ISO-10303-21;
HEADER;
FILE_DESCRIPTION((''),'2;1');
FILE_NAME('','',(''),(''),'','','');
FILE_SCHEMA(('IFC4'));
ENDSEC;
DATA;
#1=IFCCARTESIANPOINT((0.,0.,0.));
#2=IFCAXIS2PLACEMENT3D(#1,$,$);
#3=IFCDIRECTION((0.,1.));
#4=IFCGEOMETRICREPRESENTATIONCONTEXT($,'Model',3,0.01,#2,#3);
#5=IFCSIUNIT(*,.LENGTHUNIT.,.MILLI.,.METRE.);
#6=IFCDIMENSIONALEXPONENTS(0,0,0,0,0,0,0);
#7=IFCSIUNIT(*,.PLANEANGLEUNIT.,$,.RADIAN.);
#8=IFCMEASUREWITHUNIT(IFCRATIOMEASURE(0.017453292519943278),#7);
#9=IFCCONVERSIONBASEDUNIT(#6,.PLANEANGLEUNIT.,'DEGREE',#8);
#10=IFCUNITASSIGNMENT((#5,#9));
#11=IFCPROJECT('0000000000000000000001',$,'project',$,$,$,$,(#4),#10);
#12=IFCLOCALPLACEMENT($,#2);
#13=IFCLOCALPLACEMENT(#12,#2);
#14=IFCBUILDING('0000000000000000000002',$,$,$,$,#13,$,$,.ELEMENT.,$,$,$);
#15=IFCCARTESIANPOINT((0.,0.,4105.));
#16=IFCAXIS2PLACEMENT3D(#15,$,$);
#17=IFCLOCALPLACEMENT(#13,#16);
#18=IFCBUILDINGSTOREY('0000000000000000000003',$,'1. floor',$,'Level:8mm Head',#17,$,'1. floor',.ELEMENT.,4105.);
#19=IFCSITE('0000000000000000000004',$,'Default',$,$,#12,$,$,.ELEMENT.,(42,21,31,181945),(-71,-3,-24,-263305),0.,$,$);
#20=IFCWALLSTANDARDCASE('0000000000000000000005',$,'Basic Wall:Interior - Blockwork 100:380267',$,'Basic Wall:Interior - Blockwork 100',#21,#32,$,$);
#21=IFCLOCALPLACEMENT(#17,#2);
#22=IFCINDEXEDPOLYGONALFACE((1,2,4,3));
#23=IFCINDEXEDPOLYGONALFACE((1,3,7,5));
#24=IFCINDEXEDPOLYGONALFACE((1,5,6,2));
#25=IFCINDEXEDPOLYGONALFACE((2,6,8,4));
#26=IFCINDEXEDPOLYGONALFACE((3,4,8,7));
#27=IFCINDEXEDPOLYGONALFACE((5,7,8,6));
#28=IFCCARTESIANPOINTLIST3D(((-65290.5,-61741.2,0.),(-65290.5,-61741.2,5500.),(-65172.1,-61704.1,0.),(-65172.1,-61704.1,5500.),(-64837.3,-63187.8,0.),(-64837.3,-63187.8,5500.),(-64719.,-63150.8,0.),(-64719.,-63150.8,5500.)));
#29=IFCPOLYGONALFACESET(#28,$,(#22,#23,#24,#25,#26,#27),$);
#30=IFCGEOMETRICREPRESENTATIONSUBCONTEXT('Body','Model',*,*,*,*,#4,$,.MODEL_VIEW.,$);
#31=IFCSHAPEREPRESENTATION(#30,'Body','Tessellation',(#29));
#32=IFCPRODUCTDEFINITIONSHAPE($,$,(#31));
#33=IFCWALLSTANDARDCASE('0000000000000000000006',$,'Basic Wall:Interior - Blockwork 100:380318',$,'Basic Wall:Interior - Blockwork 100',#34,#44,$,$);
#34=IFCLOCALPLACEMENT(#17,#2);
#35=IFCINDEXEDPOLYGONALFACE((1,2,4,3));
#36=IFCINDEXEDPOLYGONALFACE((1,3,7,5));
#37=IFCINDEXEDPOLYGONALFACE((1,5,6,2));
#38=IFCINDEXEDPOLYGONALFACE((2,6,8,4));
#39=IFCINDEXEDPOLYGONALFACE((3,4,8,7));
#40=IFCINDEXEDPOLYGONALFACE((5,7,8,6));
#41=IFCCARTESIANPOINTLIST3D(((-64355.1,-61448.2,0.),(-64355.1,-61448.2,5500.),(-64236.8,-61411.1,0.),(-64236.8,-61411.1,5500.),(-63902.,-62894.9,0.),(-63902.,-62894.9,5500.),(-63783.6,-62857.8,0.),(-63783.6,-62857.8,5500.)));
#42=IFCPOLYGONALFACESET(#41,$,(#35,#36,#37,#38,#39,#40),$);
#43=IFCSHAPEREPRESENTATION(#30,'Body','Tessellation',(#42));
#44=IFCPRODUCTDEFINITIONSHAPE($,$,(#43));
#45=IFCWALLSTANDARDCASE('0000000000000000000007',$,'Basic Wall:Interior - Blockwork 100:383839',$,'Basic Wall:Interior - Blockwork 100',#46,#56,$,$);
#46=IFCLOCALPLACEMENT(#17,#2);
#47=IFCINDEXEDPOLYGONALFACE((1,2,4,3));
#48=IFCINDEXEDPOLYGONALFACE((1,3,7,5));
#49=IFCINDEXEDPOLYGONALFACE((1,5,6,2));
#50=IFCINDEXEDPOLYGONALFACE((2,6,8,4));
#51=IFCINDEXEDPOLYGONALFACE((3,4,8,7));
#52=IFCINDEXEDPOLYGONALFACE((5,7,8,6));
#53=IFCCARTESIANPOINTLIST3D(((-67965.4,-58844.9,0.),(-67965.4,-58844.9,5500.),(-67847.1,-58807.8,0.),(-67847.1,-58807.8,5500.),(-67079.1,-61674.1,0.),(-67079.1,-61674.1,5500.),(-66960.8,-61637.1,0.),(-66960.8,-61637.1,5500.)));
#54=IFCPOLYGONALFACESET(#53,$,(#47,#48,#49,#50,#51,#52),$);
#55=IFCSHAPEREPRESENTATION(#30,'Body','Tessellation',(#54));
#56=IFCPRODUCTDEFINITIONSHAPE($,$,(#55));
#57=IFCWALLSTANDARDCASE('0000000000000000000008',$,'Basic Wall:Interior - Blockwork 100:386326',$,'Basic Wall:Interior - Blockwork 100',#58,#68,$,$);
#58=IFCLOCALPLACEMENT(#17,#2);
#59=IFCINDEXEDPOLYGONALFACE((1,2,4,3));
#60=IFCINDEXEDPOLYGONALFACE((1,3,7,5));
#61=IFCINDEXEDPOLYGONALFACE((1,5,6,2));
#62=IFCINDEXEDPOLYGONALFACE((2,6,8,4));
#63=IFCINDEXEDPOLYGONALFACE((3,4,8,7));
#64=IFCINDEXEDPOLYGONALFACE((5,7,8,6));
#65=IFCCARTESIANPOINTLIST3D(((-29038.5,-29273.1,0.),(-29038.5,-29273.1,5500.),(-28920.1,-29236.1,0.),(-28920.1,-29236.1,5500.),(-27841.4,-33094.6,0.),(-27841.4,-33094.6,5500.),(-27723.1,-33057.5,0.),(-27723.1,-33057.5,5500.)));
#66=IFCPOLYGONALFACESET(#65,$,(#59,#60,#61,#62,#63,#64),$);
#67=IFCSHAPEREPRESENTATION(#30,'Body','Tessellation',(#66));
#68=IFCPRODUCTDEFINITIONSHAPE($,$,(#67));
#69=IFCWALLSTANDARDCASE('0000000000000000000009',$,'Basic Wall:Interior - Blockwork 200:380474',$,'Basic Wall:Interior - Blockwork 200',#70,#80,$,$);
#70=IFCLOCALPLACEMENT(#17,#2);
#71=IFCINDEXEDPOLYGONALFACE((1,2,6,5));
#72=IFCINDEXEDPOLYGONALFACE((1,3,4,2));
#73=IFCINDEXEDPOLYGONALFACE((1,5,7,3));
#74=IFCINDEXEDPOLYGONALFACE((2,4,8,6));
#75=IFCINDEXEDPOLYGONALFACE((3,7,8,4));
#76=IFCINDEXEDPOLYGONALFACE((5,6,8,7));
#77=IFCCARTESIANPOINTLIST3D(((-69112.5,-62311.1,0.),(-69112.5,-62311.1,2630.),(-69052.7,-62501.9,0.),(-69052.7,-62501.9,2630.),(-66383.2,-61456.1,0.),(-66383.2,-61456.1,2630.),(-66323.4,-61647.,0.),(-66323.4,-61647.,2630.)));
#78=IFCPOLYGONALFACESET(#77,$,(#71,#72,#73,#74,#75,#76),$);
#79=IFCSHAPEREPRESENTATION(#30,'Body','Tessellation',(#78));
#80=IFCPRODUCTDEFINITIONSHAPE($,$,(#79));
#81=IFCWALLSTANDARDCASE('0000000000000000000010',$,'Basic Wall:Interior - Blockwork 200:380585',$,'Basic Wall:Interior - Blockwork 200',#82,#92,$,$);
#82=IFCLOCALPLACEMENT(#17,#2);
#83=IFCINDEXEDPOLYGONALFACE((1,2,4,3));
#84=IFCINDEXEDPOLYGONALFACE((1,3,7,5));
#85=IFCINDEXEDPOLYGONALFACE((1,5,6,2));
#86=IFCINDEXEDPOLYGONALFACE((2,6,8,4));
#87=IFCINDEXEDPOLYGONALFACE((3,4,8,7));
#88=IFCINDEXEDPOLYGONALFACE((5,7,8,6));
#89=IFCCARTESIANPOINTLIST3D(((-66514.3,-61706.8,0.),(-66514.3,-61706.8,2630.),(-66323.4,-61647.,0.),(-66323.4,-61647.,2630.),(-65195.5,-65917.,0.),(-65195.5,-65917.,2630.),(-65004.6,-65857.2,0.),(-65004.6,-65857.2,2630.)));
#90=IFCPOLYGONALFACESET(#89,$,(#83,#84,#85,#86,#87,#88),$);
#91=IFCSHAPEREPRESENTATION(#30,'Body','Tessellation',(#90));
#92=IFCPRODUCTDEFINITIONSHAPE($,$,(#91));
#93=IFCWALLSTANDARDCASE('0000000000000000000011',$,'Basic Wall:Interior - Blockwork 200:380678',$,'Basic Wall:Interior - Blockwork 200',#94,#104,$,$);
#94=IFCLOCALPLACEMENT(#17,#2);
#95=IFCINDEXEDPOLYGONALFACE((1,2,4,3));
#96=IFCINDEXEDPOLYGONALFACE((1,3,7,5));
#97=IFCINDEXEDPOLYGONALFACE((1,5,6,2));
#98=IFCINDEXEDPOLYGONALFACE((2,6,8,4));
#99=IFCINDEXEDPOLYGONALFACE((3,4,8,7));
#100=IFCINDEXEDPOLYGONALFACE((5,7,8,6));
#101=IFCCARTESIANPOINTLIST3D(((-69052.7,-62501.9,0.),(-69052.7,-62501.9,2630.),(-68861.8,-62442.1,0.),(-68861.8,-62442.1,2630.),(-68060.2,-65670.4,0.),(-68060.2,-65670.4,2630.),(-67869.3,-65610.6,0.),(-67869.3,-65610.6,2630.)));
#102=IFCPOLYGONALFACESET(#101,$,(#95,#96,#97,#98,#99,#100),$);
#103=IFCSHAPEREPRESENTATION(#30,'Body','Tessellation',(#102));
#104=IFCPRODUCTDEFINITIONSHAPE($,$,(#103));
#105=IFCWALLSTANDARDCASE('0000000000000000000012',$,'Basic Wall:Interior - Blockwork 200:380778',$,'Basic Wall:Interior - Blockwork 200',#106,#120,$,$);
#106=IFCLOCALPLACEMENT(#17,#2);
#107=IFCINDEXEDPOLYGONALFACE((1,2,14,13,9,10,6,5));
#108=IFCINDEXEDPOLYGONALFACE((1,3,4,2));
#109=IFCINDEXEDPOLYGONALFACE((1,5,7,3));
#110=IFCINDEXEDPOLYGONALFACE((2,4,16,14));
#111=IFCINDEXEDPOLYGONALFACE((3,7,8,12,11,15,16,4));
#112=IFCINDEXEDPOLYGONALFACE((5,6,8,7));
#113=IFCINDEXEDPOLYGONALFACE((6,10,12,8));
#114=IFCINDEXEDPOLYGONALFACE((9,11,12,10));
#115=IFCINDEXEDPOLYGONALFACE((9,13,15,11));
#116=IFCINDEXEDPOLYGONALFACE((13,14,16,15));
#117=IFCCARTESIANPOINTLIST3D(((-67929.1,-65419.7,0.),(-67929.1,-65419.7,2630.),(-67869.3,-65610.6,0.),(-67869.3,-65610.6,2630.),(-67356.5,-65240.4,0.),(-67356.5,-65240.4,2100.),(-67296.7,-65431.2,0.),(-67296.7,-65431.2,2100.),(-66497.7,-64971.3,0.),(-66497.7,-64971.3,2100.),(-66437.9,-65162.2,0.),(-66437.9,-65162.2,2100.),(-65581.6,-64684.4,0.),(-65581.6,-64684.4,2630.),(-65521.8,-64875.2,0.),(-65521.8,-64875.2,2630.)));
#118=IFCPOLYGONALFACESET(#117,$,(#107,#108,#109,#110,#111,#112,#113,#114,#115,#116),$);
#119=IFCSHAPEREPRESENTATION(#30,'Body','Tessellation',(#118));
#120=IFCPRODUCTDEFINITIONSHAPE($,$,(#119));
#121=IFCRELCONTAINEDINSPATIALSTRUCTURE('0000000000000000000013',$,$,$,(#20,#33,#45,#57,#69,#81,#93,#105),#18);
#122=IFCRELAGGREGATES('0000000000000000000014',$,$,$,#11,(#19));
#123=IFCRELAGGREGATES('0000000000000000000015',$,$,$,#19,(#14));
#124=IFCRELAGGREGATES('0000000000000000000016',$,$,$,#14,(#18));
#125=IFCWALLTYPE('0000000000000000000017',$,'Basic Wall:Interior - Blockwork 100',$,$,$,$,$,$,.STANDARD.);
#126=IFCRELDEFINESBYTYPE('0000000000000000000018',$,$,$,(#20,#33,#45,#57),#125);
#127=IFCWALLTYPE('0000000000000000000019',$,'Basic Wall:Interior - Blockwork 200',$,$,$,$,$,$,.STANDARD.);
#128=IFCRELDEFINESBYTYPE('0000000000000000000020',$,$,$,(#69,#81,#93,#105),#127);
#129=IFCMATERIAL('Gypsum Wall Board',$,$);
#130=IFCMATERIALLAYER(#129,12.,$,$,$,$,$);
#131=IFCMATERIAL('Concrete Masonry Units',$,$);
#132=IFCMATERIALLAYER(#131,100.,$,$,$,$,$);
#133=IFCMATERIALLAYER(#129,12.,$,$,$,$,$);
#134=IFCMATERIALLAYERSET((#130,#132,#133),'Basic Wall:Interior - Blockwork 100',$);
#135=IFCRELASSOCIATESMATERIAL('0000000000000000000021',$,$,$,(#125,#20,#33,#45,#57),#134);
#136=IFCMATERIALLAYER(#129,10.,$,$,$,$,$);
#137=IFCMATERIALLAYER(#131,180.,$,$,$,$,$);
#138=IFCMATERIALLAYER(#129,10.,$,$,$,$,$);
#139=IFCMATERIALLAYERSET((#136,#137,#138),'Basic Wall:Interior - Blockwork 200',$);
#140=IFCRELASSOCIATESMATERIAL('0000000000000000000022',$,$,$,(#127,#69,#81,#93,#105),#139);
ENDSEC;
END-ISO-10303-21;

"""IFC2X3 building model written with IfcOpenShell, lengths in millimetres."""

from ifc_helpers import new_model, entity, si_unit, converted_unit, direction, frame, frame_2d, origin, place, context, subcontext, project, spatial, rectangle, extrude, material, layer, layer_set, layer_usage, type_object, element, save


model = new_model("IFC2X3")

# Units and contexts
model_context = context("Model", 3, precision=0.01, world=origin(), true_north=direction((0.0, 1.0)))
body_context = subcontext(model_context, "Body", "Model", "MODEL_VIEW")
ifc_project = project(units=[si_unit("LENGTHUNIT", "METRE", prefix="MILLI"), converted_unit("PLANEANGLEUNIT", "DEGREE", entity("IfcRatioMeasure", 0.017453292519943278), si_unit("PLANEANGLEUNIT", "RADIAN"), dimensions=[0, 0, 0, 0, 0, 0, 0])], contexts=[model_context])

# Site, building, storey
site_placement = place(None, origin())
site = spatial("IfcSite", under=ifc_project, at=site_placement, Name="Default", CompositionType="ELEMENT", RefLatitude=(42, 21, 31, 181945), RefLongitude=(-71, -3, -24, -263305), RefElevation=0.0)
building_placement = place(site_placement, origin())
building = spatial("IfcBuilding", under=site, at=building_placement, CompositionType="ELEMENT")
storey_placement = place(building_placement, frame((0.0, 0.0, 4105.0)))
storey = spatial("IfcBuildingStorey", under=building, at=storey_placement, Name="1. floor", ObjectType="Level:8mm Head", LongName="1. floor", CompositionType="ELEMENT", Elevation=4105.0)

# Shared definitions
ifc_material_1 = material(Name="Gypsum Wall Board")

# Shared definitions
ifc_layer_1 = layer(ifc_material_1, 12.0)
ifc_material_2 = material(Name="Concrete Masonry Units")
ifc_layer_2 = layer(ifc_material_2, 100.0)
ifc_layer_3 = layer(ifc_material_1, 12.0)
ifc_layer_set_1 = layer_set([ifc_layer_1, ifc_layer_2, ifc_layer_3], Name="Basic Wall:Interior - Blockwork 100")
wall_type_1 = type_object("IfcWallType", Name="Basic Wall:Interior - Blockwork 100", PredefinedType="STANDARD", material=ifc_layer_set_1)

# Walls
ifc_layer_usage_1 = layer_usage(ifc_layer_set_1, "AXIS2", "NEGATIVE", 62.0)
wall_1_placement = place(storey_placement, frame((-65231.3, -61722.6, 0.0), z_axis=(0.0, 0.0, 1.0), x_axis=(0.298924, -0.954277, 0.0)))
element("IfcWallStandardCase", 1, at=wall_1_placement, inside=storey, type_object=wall_type_1, material=ifc_layer_usage_1, Name="Basic Wall:Interior - Blockwork 100:380267", ObjectType="Basic Wall:Interior - Blockwork 100", context=body_context, shape_type="SweptSolid", body=[
    extrude(rectangle(XDim=1516.0, YDim=124.0, at=frame_2d((758.0, 0.0), x_axis=(-1.0, 0.0))), origin(), (0.0, 0.0, 1.0), 5500.0),
])
ifc_layer_usage_2 = layer_usage(ifc_layer_set_1, "AXIS2", "NEGATIVE", 62.0)
wall_2_placement = place(storey_placement, frame((-64296.0, -61429.6, 0.0), z_axis=(0.0, 0.0, 1.0), x_axis=(0.298924, -0.954277, 0.0)))
element("IfcWallStandardCase", 2, at=wall_2_placement, inside=storey, type_object=wall_type_1, material=ifc_layer_usage_2, Name="Basic Wall:Interior - Blockwork 100:380318", ObjectType="Basic Wall:Interior - Blockwork 100", context=body_context, shape_type="SweptSolid", body=[
    extrude(rectangle(XDim=1516.0, YDim=124.0, at=frame_2d((758.0, 0.0), x_axis=(-1.0, 0.0))), origin(), (0.0, 0.0, 1.0), 5500.0),
])
ifc_layer_usage_3 = layer_usage(ifc_layer_set_1, "AXIS2", "NEGATIVE", 62.0)
wall_3_placement = place(storey_placement, frame((-67906.2, -58826.3, 0.0), z_axis=(0.0, 0.0, 1.0), x_axis=(0.298924, -0.954277, 0.0)))
element("IfcWallStandardCase", 3, at=wall_3_placement, inside=storey, type_object=wall_type_1, material=ifc_layer_usage_3, Name="Basic Wall:Interior - Blockwork 100:383839", ObjectType="Basic Wall:Interior - Blockwork 100", context=body_context, shape_type="SweptSolid", body=[
    extrude(rectangle(XDim=2964.8, YDim=124.0, at=frame_2d((1482.4, 0.0), x_axis=(-1.0, 0.0))), origin(), (0.0, 0.0, 1.0), 5500.0),
])
ifc_layer_usage_4 = layer_usage(ifc_layer_set_1, "AXIS2", "NEGATIVE", 62.0)
wall_4_placement = place(storey_placement, frame((-28979.3, -29254.6, 0.0), z_axis=(0.0, 0.0, 1.0), x_axis=(0.298924, -0.954277, 0.0)))
element("IfcWallStandardCase", 4, at=wall_4_placement, inside=storey, type_object=wall_type_1, material=ifc_layer_usage_4, Name="Basic Wall:Interior - Blockwork 100:386326", ObjectType="Basic Wall:Interior - Blockwork 100", context=body_context, shape_type="SweptSolid", body=[
    extrude(rectangle(XDim=4004.5, YDim=124.0, at=frame_2d((2002.3, 0.0), x_axis=(-1.0, 0.0))), origin(), (0.0, 0.0, 1.0), 5500.0),
])
ifc_layer_4 = layer(ifc_material_1, 10.0)
ifc_layer_5 = layer(ifc_material_2, 180.0)
ifc_layer_6 = layer(ifc_material_1, 10.0)
ifc_layer_set_2 = layer_set([ifc_layer_4, ifc_layer_5, ifc_layer_6], Name="Basic Wall:Interior - Blockwork 200")
ifc_layer_usage_5 = layer_usage(ifc_layer_set_2, "AXIS2", "NEGATIVE", 100.0)
wall_type_2 = type_object("IfcWallType", Name="Basic Wall:Interior - Blockwork 200", PredefinedType="STANDARD", material=ifc_layer_set_2)
wall_5_placement = place(storey_placement, frame((-69082.6, -62406.5, 0.0), z_axis=(0.0, 0.0, 1.0), x_axis=(0.954277, 0.298924, 0.0)))
element("IfcWallStandardCase", 5, at=wall_5_placement, inside=storey, type_object=wall_type_2, material=ifc_layer_usage_5, Name="Basic Wall:Interior - Blockwork 200:380474", ObjectType="Basic Wall:Interior - Blockwork 200", context=body_context, shape_type="SweptSolid", body=[
    extrude(rectangle(XDim=2860.0, YDim=200.0, at=frame_2d((1430.0, 0.0), x_axis=(-1.0, 0.0))), origin(), (0.0, 0.0, 1.0), 2630.0),
])
ifc_layer_usage_6 = layer_usage(ifc_layer_set_2, "AXIS2", "NEGATIVE", 100.0)
wall_6_placement = place(storey_placement, frame((-66418.9, -61676.9, 0.0), z_axis=(0.0, 0.0, 1.0), x_axis=(0.298924, -0.954277, 0.0)))
element("IfcWallStandardCase", 6, at=wall_6_placement, inside=storey, type_object=wall_type_2, material=ifc_layer_usage_6, Name="Basic Wall:Interior - Blockwork 200:380585", ObjectType="Basic Wall:Interior - Blockwork 200", context=body_context, shape_type="SweptSolid", body=[
    extrude(rectangle(XDim=4412.0, YDim=200.0, at=frame_2d((2206.0, 0.0), x_axis=(-1.0, 0.0))), origin(), (0.0, 0.0, 1.0), 2630.0),
])
ifc_layer_usage_7 = layer_usage(ifc_layer_set_2, "AXIS2", "NEGATIVE", 100.0)
wall_7_placement = place(storey_placement, frame((-68957.2, -62472.0, 0.0), z_axis=(0.0, 0.0, 1.0), x_axis=(0.298924, -0.954277, 0.0)))
element("IfcWallStandardCase", 7, at=wall_7_placement, inside=storey, type_object=wall_type_2, material=ifc_layer_usage_7, Name="Basic Wall:Interior - Blockwork 200:380678", ObjectType="Basic Wall:Interior - Blockwork 200", context=body_context, shape_type="SweptSolid", body=[
    extrude(rectangle(XDim=3320.3, YDim=200.0, at=frame_2d((1660.1, 0.0), x_axis=(-1.0, 0.0))), origin(), (0.0, 0.0, 1.0), 2630.0),
])

# Wall, opening
ifc_layer_usage_8 = layer_usage(ifc_layer_set_2, "AXIS2", "NEGATIVE", 100.0)
wall_8_placement = place(storey_placement, frame((-65551.7, -64779.8, 0.0), z_axis=(0.0, 0.0, 1.0), x_axis=(-0.954277, -0.298924, 0.0)))
wall_8 = element("IfcWallStandardCase", 8, at=wall_8_placement, inside=storey, type_object=wall_type_2, material=ifc_layer_usage_8, Name="Basic Wall:Interior - Blockwork 200:380778", ObjectType="Basic Wall:Interior - Blockwork 200", context=body_context, shape_type="SweptSolid", body=[
    extrude(rectangle(XDim=2460.0, YDim=200.0, at=frame_2d((1230.0, 0.0), x_axis=(-1.0, 0.0))), origin(), (0.0, 0.0, 1.0), 2630.0),
])
opening_1_placement = place(wall_8_placement, origin())
element("IfcOpeningElement", 9, at=opening_1_placement, cuts=wall_8, ObjectType="Opening", context=body_context, shape_type="SweptSolid", body=[
    extrude(rectangle(XDim=2100.0, YDim=900.0, at=frame_2d((0.0, 0.0), x_axis=(0.0, 1.0))), frame((1410.0, -1624.0, 1050.0), z_axis=(0.0, 1.0, 0.0), x_axis=(-1.0, 0.0, 0.0)), (0.0, 0.0, 1.0), 3048.0),
])

save(model, "model.ifc")
